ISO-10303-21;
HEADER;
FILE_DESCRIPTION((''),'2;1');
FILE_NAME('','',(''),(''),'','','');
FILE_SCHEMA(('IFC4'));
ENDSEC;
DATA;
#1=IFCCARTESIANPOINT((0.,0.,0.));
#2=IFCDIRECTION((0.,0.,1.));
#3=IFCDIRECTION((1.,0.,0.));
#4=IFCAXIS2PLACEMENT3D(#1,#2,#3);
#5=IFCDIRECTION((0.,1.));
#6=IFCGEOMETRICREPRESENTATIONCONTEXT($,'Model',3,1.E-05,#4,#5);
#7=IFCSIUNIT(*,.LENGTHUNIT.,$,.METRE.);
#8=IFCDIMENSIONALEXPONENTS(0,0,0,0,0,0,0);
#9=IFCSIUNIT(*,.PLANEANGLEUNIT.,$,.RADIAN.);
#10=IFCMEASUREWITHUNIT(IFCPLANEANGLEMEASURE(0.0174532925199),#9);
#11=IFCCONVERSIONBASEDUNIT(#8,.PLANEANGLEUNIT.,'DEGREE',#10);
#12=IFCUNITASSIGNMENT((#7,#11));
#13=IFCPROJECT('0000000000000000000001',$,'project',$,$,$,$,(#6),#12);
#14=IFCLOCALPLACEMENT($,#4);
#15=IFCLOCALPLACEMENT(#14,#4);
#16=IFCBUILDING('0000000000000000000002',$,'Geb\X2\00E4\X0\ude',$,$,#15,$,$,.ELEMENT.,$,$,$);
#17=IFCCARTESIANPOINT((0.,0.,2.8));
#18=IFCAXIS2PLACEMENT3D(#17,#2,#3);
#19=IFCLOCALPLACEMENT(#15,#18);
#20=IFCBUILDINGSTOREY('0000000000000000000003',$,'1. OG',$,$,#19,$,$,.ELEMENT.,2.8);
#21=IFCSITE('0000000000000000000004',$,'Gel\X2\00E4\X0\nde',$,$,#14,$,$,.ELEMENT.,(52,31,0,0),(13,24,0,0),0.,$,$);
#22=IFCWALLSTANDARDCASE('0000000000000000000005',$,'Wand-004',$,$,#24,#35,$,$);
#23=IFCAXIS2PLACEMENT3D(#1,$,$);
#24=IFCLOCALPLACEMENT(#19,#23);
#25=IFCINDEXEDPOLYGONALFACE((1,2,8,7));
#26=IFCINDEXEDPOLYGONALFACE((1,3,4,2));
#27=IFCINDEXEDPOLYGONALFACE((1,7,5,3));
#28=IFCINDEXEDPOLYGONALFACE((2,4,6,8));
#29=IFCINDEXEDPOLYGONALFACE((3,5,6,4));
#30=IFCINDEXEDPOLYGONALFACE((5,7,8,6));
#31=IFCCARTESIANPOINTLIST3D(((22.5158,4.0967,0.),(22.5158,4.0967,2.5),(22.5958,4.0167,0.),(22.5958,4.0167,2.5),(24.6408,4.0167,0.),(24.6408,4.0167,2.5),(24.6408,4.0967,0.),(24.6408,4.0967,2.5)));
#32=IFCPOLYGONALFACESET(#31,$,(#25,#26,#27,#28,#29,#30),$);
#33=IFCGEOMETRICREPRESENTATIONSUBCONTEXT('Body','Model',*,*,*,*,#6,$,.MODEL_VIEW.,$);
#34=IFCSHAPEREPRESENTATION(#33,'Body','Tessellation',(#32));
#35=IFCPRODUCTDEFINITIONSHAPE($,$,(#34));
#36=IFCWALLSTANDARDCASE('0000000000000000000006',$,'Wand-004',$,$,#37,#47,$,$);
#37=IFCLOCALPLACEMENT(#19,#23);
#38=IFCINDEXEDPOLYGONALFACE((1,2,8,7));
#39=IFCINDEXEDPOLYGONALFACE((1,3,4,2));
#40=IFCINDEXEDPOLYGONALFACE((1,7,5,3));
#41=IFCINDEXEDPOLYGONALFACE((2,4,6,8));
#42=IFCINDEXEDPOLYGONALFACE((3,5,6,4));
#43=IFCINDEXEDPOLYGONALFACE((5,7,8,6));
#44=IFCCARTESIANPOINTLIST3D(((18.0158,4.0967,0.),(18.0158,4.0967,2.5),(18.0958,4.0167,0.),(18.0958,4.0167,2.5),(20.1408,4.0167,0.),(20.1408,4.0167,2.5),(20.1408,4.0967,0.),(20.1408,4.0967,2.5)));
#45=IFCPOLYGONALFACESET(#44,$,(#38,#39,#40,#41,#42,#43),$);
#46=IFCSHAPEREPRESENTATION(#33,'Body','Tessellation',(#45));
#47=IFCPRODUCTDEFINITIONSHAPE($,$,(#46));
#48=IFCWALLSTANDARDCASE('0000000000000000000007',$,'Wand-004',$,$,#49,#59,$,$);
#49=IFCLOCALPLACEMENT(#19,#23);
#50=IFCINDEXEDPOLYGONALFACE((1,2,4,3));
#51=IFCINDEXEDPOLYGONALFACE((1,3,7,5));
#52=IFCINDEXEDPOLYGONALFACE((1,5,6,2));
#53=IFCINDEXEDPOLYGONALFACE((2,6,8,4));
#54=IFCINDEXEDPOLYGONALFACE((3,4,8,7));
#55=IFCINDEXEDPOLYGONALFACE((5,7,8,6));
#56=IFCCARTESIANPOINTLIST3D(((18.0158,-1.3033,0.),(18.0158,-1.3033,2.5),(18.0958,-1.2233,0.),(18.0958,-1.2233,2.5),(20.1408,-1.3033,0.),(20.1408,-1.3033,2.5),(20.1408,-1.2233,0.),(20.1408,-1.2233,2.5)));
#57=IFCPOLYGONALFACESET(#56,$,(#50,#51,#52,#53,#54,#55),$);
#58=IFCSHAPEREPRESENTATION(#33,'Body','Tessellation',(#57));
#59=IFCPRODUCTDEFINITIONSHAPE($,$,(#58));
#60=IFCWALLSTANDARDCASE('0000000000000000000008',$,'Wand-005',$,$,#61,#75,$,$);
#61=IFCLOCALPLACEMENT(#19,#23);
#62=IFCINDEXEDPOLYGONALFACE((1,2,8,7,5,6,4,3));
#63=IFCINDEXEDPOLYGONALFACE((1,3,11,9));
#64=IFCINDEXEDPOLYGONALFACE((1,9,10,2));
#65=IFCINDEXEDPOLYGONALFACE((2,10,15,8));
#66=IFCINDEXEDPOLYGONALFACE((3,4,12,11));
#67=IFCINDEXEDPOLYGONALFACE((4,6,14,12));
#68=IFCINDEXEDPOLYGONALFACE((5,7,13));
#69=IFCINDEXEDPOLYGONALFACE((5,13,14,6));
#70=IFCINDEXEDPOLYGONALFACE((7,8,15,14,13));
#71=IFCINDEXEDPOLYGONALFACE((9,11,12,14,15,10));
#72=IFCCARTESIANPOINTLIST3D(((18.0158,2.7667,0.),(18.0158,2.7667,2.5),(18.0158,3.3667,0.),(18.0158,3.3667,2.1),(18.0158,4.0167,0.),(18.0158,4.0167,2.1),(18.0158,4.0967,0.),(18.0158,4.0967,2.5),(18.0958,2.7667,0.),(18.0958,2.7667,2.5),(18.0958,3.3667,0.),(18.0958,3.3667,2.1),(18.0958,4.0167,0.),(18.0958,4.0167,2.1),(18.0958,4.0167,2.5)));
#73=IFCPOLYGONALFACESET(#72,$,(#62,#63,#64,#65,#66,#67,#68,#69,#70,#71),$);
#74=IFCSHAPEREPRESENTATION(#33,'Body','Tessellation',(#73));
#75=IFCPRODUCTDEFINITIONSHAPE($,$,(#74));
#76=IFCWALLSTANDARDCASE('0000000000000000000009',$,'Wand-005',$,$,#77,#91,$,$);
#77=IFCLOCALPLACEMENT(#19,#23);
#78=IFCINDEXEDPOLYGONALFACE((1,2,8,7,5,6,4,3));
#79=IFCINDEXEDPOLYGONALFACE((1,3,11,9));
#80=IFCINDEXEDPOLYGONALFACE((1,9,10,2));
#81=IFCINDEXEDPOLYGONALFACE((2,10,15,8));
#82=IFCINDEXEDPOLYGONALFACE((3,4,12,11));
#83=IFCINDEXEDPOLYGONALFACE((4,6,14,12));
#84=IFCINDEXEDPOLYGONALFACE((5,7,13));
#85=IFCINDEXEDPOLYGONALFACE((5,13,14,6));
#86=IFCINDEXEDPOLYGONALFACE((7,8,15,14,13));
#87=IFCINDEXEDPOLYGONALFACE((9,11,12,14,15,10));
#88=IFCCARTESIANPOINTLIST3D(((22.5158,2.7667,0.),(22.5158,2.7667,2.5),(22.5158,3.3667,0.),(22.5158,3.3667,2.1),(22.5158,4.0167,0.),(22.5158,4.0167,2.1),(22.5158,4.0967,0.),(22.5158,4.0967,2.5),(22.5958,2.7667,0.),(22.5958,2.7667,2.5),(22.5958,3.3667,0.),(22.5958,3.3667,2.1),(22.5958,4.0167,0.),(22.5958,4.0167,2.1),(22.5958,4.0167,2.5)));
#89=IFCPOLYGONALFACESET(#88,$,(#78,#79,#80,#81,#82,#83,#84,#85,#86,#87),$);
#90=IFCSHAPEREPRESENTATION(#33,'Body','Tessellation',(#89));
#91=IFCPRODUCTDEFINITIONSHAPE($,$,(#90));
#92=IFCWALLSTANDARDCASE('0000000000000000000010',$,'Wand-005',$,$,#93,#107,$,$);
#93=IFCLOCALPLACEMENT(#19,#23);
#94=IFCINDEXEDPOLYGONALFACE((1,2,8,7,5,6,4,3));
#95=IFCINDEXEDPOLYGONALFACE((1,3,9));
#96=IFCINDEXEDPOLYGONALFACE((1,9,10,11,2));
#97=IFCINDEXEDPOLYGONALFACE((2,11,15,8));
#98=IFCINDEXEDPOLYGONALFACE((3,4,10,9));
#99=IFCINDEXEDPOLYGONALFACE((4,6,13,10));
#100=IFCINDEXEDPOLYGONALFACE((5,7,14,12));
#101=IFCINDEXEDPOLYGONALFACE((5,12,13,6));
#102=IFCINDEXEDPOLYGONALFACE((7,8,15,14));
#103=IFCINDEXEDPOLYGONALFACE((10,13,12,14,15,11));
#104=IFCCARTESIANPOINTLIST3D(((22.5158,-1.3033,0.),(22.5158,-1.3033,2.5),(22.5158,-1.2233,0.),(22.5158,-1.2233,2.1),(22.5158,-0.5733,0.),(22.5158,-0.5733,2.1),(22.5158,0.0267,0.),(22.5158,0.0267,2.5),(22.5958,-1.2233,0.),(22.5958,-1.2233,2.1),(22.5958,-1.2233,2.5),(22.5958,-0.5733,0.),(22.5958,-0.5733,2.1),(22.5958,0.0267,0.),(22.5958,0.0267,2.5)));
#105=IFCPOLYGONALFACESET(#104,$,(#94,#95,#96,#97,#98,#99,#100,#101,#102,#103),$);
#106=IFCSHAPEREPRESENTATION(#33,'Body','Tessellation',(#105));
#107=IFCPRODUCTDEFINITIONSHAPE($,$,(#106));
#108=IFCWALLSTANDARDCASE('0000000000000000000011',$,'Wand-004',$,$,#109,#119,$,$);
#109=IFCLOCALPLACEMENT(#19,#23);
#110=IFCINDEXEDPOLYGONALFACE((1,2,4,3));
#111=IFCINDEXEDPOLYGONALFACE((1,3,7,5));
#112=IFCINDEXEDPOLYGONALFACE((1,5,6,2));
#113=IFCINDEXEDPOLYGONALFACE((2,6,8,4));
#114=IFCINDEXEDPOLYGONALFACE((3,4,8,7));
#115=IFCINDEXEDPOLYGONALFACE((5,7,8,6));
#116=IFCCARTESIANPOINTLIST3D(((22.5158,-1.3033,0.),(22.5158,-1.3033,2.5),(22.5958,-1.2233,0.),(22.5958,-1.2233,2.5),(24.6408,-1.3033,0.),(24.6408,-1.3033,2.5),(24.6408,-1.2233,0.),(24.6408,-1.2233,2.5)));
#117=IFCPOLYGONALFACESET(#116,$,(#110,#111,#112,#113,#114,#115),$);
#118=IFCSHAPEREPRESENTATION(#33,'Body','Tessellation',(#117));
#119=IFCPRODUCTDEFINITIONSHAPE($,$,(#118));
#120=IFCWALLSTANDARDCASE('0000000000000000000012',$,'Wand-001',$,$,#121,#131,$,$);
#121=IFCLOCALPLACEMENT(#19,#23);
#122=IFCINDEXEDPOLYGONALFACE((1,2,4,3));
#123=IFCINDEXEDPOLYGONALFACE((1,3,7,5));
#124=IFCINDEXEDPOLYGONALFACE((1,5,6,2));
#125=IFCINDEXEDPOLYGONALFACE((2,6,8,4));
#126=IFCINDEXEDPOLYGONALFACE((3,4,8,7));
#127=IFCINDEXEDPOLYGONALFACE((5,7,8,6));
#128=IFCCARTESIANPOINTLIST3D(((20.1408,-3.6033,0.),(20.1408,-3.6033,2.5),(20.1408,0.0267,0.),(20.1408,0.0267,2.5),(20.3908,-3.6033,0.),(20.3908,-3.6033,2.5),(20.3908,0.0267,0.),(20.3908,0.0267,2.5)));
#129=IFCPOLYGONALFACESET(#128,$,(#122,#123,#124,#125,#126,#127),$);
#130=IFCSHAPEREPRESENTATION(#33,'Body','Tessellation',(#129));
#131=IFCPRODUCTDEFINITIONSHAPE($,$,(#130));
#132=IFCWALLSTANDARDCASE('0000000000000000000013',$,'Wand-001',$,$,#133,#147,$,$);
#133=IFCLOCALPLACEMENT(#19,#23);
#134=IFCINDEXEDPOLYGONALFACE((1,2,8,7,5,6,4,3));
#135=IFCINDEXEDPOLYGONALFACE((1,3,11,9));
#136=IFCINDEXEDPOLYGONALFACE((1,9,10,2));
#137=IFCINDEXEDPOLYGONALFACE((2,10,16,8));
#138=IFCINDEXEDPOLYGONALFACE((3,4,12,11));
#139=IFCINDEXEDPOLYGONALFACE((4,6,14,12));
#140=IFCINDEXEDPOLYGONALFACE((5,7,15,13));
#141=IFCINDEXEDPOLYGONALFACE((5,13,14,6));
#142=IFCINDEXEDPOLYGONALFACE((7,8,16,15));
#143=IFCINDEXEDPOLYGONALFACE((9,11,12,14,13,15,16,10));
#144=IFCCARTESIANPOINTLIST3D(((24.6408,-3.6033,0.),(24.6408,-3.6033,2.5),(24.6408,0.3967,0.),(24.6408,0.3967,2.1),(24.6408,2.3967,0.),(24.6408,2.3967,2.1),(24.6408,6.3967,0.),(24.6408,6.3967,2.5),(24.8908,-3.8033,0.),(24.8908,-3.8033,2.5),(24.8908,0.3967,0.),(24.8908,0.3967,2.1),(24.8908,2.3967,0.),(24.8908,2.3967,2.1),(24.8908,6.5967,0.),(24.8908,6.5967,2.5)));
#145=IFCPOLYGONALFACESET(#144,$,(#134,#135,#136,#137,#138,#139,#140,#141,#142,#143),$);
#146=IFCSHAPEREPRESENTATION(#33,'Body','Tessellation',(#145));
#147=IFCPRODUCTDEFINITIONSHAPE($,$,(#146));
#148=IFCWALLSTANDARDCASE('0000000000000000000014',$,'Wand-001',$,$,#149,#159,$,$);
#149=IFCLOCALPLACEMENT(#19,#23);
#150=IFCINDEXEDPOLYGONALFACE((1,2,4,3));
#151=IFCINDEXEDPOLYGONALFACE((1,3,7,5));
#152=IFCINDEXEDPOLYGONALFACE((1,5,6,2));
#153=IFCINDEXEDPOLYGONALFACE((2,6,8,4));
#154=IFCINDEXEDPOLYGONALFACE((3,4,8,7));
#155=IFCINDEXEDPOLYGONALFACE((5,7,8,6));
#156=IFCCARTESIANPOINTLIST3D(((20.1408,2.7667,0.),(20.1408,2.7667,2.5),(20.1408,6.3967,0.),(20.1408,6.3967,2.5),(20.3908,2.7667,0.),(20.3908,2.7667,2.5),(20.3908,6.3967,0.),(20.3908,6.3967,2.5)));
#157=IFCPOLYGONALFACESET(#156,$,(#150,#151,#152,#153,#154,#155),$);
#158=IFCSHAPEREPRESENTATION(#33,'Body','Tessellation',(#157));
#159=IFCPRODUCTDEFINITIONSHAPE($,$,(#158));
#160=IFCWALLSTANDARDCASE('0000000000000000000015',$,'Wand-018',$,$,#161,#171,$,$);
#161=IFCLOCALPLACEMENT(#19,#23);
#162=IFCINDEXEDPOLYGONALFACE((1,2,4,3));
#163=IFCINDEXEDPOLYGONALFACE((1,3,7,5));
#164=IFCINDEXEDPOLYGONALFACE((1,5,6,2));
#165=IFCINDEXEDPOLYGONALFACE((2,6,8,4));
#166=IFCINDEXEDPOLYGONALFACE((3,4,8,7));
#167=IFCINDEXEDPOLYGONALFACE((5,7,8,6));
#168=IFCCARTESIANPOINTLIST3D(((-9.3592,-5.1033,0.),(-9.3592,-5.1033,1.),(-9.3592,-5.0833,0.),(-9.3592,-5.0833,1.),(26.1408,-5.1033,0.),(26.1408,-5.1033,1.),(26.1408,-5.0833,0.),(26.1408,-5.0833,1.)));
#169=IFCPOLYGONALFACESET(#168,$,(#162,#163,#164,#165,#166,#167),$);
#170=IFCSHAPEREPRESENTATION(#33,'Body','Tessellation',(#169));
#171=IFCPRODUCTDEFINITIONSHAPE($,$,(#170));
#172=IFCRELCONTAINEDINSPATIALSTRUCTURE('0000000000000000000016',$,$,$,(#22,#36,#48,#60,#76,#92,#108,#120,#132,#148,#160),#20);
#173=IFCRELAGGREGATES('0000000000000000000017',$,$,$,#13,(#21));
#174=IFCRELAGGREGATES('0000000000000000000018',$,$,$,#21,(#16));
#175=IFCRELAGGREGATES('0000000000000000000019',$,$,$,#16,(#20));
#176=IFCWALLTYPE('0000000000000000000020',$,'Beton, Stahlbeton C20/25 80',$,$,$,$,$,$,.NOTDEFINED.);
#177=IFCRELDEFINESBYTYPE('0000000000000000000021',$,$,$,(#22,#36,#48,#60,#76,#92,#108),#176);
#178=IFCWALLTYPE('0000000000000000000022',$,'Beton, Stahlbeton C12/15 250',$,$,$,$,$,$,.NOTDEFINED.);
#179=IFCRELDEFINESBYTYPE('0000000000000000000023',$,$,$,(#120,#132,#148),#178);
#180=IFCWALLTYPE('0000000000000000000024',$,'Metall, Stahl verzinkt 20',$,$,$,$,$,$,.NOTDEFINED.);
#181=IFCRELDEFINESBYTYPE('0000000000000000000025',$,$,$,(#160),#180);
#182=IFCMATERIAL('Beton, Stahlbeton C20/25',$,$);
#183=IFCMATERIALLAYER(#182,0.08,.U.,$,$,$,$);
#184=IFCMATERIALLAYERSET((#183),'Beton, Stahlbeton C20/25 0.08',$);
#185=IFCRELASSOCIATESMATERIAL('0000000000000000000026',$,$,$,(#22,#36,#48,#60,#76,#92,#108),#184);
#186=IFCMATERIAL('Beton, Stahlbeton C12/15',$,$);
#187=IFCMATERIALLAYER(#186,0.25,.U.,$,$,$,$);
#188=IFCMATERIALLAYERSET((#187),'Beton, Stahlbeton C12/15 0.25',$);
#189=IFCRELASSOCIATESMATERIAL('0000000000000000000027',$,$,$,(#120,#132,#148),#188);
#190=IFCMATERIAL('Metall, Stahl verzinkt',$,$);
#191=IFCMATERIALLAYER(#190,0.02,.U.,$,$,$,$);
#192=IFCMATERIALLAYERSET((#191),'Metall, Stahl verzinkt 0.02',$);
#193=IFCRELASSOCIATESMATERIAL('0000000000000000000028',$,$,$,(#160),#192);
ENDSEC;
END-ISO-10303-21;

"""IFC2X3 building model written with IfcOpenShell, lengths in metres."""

from ifc_helpers import new_model, entity, si_unit, converted_unit, direction, frame, origin_with_axes, origin_2d_with_axis, place, context, subcontext, project, spatial, polyline, rectangle, outline, extrude, material, layer, layer_set, layer_usage, type_object, element, save


model = new_model("IFC2X3")

# Units and contexts
model_context = context("Model", 3, precision=1e-05, world=origin_with_axes(), true_north=direction((0.0, 1.0)))
body_context = subcontext(model_context, "Body", "Model", "MODEL_VIEW")
ifc_project = project(units=[si_unit("LENGTHUNIT", "METRE"), converted_unit("PLANEANGLEUNIT", "DEGREE", entity("IfcPlaneAngleMeasure", 0.0174532925199), si_unit("PLANEANGLEUNIT", "RADIAN"), dimensions=[0, 0, 0, 0, 0, 0, 0])], contexts=[model_context])

# Site, building, storey
site_placement = place(None, origin_with_axes())
site = spatial("IfcSite", under=ifc_project, at=site_placement, Name="Gelände", CompositionType="ELEMENT", RefLatitude=(52, 31, 0, 0), RefLongitude=(13, 24, 0, 0), RefElevation=0.0)
building_placement = place(site_placement, origin_with_axes())
building = spatial("IfcBuilding", under=site, at=building_placement, Name="Gebäude", CompositionType="ELEMENT")
storey_placement = place(building_placement, frame((0.0, 0.0, 2.8), z_axis=(0.0, 0.0, 1.0), x_axis=(1.0, 0.0, 0.0)))
storey = spatial("IfcBuildingStorey", under=building, at=storey_placement, Name="1. OG", CompositionType="ELEMENT", Elevation=2.8)

# Walls
ifc_material_1 = material(Name="Beton, Stahlbeton C20/25")
ifc_layer_1 = layer(ifc_material_1, 0.08, ventilated="UNKNOWN")
ifc_layer_set_1 = layer_set([ifc_layer_1], Name="Beton, Stahlbeton C20/25 0.08")
ifc_layer_usage_1 = layer_usage(ifc_layer_set_1, "AXIS2", "POSITIVE", 0.0)
wall_type_1 = type_object("IfcWallType", Name="Beton, Stahlbeton C20/25 80", PredefinedType="NOTDEFINED")
wall_1_placement = place(storey_placement, frame((24.6408, 4.0967, 0.0), z_axis=(0.0, 0.0, 1.0), x_axis=(-1.0, 0.0, 0.0)))
element("IfcWallStandardCase", 1, at=wall_1_placement, inside=storey, type_object=wall_type_1, material=ifc_layer_usage_1, Name="Wand-004", context=body_context, shape_type="SweptSolid", body=[
    extrude(outline(polyline([(0.0, 0.0), (2.125, 0.0), (2.045, 0.08), (0.0, 0.08), (0.0, 0.0)])), origin_with_axes(), (0.0, 0.0, 1.0), 2.5),
])
ifc_layer_usage_2 = layer_usage(ifc_layer_set_1, "AXIS2", "POSITIVE", 0.0)
wall_2_placement = place(storey_placement, frame((20.1408, 4.0967, 0.0), z_axis=(0.0, 0.0, 1.0), x_axis=(-1.0, 0.0, 0.0)))
element("IfcWallStandardCase", 2, at=wall_2_placement, inside=storey, type_object=wall_type_1, material=ifc_layer_usage_2, Name="Wand-004", context=body_context, shape_type="SweptSolid", body=[
    extrude(outline(polyline([(0.0, 0.0), (2.125, 0.0), (2.045, 0.08), (0.0, 0.08), (0.0, 0.0)])), origin_with_axes(), (0.0, 0.0, 1.0), 2.5),
])
ifc_layer_usage_3 = layer_usage(ifc_layer_set_1, "AXIS2", "NEGATIVE", 0.0)
wall_3_placement = place(storey_placement, frame((20.1408, -1.3033, 0.0), z_axis=(0.0, 0.0, 1.0), x_axis=(-1.0, 0.0, 0.0)))
element("IfcWallStandardCase", 3, at=wall_3_placement, inside=storey, type_object=wall_type_1, material=ifc_layer_usage_3, Name="Wand-004", context=body_context, shape_type="SweptSolid", body=[
    extrude(outline(polyline([(0.0, -0.08), (2.045, -0.08), (2.125, 0.0), (0.0, 0.0), (0.0, -0.08)])), origin_with_axes(), (0.0, 0.0, 1.0), 2.5),
])

# Walls, openings
ifc_layer_usage_4 = layer_usage(ifc_layer_set_1, "AXIS2", "POSITIVE", 0.0)
wall_4_placement = place(storey_placement, frame((18.0158, 4.0967, 0.0), z_axis=(0.0, 0.0, 1.0), x_axis=(0.0, -1.0, 0.0)))
wall_4 = element("IfcWallStandardCase", 4, at=wall_4_placement, inside=storey, type_object=wall_type_1, material=ifc_layer_usage_4, Name="Wand-005", context=body_context, shape_type="SweptSolid", body=[
    extrude(outline(polyline([(0.0, 0.0), (1.33, 0.0), (1.33, 0.08), (0.08, 0.08), (0.0, 0.0)])), origin_with_axes(), (0.0, 0.0, 1.0), 2.5),
])
opening_1_placement = place(wall_4_placement, frame((0.405, 0.0, 0.0), z_axis=(0.0, 0.0, 1.0), x_axis=(1.0, 0.0, 0.0)))
element("IfcOpeningElement", 5, at=opening_1_placement, cuts=wall_4, context=body_context, shape_type="SweptSolid", body=[
    extrude(rectangle(XDim=0.65, YDim=2.1, at=origin_2d_with_axis()), frame((0.0, -0.08, 1.05), z_axis=(0.0, 1.0, 0.0), x_axis=(-1.0, 0.0, 0.0)), (0.0, 0.0, 1.0), 0.24),
])
ifc_layer_usage_5 = layer_usage(ifc_layer_set_1, "AXIS2", "POSITIVE", 0.0)
wall_5_placement = place(storey_placement, frame((22.5158, 4.0967, 0.0), z_axis=(0.0, 0.0, 1.0), x_axis=(0.0, -1.0, 0.0)))
wall_5 = element("IfcWallStandardCase", 6, at=wall_5_placement, inside=storey, type_object=wall_type_1, material=ifc_layer_usage_5, Name="Wand-005", context=body_context, shape_type="SweptSolid", body=[
    extrude(outline(polyline([(0.0, 0.0), (1.33, 0.0), (1.33, 0.08), (0.08, 0.08), (0.0, 0.0)])), origin_with_axes(), (0.0, 0.0, 1.0), 2.5),
])
opening_2_placement = place(wall_5_placement, frame((0.405, 0.0, 0.0), z_axis=(0.0, 0.0, 1.0), x_axis=(1.0, 0.0, 0.0)))
element("IfcOpeningElement", 7, at=opening_2_placement, cuts=wall_5, context=body_context, shape_type="SweptSolid", body=[
    extrude(rectangle(XDim=0.65, YDim=2.1, at=origin_2d_with_axis()), frame((0.0, -0.08, 1.05), z_axis=(0.0, 1.0, 0.0), x_axis=(-1.0, 0.0, 0.0)), (0.0, 0.0, 1.0), 0.24),
])
ifc_layer_usage_6 = layer_usage(ifc_layer_set_1, "AXIS2", "NEGATIVE", 0.0)
wall_6_placement = place(storey_placement, frame((22.5158, -1.3033, 0.0), z_axis=(0.0, 0.0, 1.0), x_axis=(0.0, 1.0, 0.0)))
wall_6 = element("IfcWallStandardCase", 8, at=wall_6_placement, inside=storey, type_object=wall_type_1, material=ifc_layer_usage_6, Name="Wand-005", context=body_context, shape_type="SweptSolid", body=[
    extrude(outline(polyline([(0.08, -0.08), (1.33, -0.08), (1.33, 0.0), (0.0, 0.0), (0.08, -0.08)])), origin_with_axes(), (0.0, 0.0, 1.0), 2.5),
])
opening_3_placement = place(wall_6_placement, frame((0.405, 0.0, 0.0), z_axis=(0.0, 0.0, 1.0), x_axis=(1.0, 0.0, 0.0)))
element("IfcOpeningElement", 9, at=opening_3_placement, cuts=wall_6, context=body_context, shape_type="SweptSolid", body=[
    extrude(rectangle(XDim=0.65, YDim=2.1, at=origin_2d_with_axis()), frame((0.0, 0.08, 1.05), z_axis=(0.0, 1.0, 0.0), x_axis=(-1.0, 0.0, 0.0)), (0.0, 0.0, -1.0), 0.24),
])

# Walls
ifc_layer_usage_7 = layer_usage(ifc_layer_set_1, "AXIS2", "NEGATIVE", 0.0)
wall_7_placement = place(storey_placement, frame((24.6408, -1.3033, 0.0), z_axis=(0.0, 0.0, 1.0), x_axis=(-1.0, 0.0, 0.0)))
element("IfcWallStandardCase", 10, at=wall_7_placement, inside=storey, type_object=wall_type_1, material=ifc_layer_usage_7, Name="Wand-004", context=body_context, shape_type="SweptSolid", body=[
    extrude(outline(polyline([(0.0, -0.08), (2.045, -0.08), (2.125, 0.0), (0.0, 0.0), (0.0, -0.08)])), origin_with_axes(), (0.0, 0.0, 1.0), 2.5),
])
ifc_material_2 = material(Name="Beton, Stahlbeton C12/15")
ifc_layer_2 = layer(ifc_material_2, 0.25, ventilated="UNKNOWN")
ifc_layer_set_2 = layer_set([ifc_layer_2], Name="Beton, Stahlbeton C12/15 0.25")
ifc_layer_usage_8 = layer_usage(ifc_layer_set_2, "AXIS2", "NEGATIVE", 0.0)
wall_type_2 = type_object("IfcWallType", Name="Beton, Stahlbeton C12/15 250", PredefinedType="NOTDEFINED")
wall_8_placement = place(storey_placement, frame((20.1408, -3.6033, 0.0), z_axis=(0.0, 0.0, 1.0), x_axis=(0.0, 1.0, 0.0)))
element("IfcWallStandardCase", 11, at=wall_8_placement, inside=storey, type_object=wall_type_2, material=ifc_layer_usage_8, Name="Wand-001", context=body_context, shape_type="SweptSolid", body=[
    extrude(outline(polyline([(0.0, -0.25), (3.63, -0.25), (3.63, 0.0), (0.0, 0.0), (0.0, -0.25)])), origin_with_axes(), (0.0, 0.0, 1.0), 2.5),
])

# Wall, opening
ifc_layer_usage_9 = layer_usage(ifc_layer_set_2, "AXIS2", "POSITIVE", 0.0)
wall_9_placement = place(storey_placement, frame((24.8908, -3.6033, 0.0), z_axis=(0.0, 0.0, 1.0), x_axis=(0.0, 1.0, 0.0)))
wall_9 = element("IfcWallStandardCase", 12, at=wall_9_placement, inside=storey, type_object=wall_type_2, material=ifc_layer_usage_9, Name="Wand-001", context=body_context, shape_type="SweptSolid", body=[
    extrude(outline(polyline([(-0.2, 0.0), (10.2, 0.0), (10.0, 0.25), (0.0, 0.25), (-0.2, 0.0)])), origin_with_axes(), (0.0, 0.0, 1.0), 2.5),
])
opening_4_placement = place(wall_9_placement, frame((5.0, 0.0, 0.0), z_axis=(0.0, 0.0, 1.0), x_axis=(1.0, 0.0, 0.0)))
element("IfcOpeningElement", 13, at=opening_4_placement, cuts=wall_9, context=body_context, shape_type="SweptSolid", body=[
    extrude(rectangle(XDim=2.0, YDim=2.1, at=origin_2d_with_axis()), frame((0.0, 0.5, 1.05), z_axis=(0.0, 1.0, 0.0), x_axis=(-1.0, 0.0, 0.0)), (0.0, 0.0, -1.0), 0.75),
])

# Walls
ifc_layer_usage_10 = layer_usage(ifc_layer_set_2, "AXIS2", "POSITIVE", 0.0)
wall_10_placement = place(storey_placement, frame((20.1408, 6.3967, 0.0), z_axis=(0.0, 0.0, 1.0), x_axis=(0.0, -1.0, 0.0)))
element("IfcWallStandardCase", 14, at=wall_10_placement, inside=storey, type_object=wall_type_2, material=ifc_layer_usage_10, Name="Wand-001", context=body_context, shape_type="SweptSolid", body=[
    extrude(outline(polyline([(0.0, 0.0), (3.63, 0.0), (3.63, 0.25), (0.0, 0.25), (0.0, 0.0)])), origin_with_axes(), (0.0, 0.0, 1.0), 2.5),
])
ifc_material_3 = material(Name="Metall, Stahl verzinkt")
ifc_layer_3 = layer(ifc_material_3, 0.02, ventilated="UNKNOWN")
ifc_layer_set_3 = layer_set([ifc_layer_3], Name="Metall, Stahl verzinkt 0.02")
ifc_layer_usage_11 = layer_usage(ifc_layer_set_3, "AXIS2", "NEGATIVE", 0.0)
wall_type_3 = type_object("IfcWallType", Name="Metall, Stahl verzinkt 20", PredefinedType="NOTDEFINED")
wall_11_placement = place(storey_placement, frame((26.1408, -5.1033, 0.0), z_axis=(0.0, 0.0, 1.0), x_axis=(-1.0, 0.0, 0.0)))
element("IfcWallStandardCase", 15, at=wall_11_placement, inside=storey, type_object=wall_type_3, material=ifc_layer_usage_11, Name="Wand-018", context=body_context, shape_type="SweptSolid", body=[
    extrude(outline(polyline([(0.0, -0.02), (35.5, -0.02), (35.5, 0.0), (0.0, 0.0), (0.0, -0.02)])), origin_with_axes(), (0.0, 0.0, 1.0), 1.0),
])

save(model, "model.ifc")
